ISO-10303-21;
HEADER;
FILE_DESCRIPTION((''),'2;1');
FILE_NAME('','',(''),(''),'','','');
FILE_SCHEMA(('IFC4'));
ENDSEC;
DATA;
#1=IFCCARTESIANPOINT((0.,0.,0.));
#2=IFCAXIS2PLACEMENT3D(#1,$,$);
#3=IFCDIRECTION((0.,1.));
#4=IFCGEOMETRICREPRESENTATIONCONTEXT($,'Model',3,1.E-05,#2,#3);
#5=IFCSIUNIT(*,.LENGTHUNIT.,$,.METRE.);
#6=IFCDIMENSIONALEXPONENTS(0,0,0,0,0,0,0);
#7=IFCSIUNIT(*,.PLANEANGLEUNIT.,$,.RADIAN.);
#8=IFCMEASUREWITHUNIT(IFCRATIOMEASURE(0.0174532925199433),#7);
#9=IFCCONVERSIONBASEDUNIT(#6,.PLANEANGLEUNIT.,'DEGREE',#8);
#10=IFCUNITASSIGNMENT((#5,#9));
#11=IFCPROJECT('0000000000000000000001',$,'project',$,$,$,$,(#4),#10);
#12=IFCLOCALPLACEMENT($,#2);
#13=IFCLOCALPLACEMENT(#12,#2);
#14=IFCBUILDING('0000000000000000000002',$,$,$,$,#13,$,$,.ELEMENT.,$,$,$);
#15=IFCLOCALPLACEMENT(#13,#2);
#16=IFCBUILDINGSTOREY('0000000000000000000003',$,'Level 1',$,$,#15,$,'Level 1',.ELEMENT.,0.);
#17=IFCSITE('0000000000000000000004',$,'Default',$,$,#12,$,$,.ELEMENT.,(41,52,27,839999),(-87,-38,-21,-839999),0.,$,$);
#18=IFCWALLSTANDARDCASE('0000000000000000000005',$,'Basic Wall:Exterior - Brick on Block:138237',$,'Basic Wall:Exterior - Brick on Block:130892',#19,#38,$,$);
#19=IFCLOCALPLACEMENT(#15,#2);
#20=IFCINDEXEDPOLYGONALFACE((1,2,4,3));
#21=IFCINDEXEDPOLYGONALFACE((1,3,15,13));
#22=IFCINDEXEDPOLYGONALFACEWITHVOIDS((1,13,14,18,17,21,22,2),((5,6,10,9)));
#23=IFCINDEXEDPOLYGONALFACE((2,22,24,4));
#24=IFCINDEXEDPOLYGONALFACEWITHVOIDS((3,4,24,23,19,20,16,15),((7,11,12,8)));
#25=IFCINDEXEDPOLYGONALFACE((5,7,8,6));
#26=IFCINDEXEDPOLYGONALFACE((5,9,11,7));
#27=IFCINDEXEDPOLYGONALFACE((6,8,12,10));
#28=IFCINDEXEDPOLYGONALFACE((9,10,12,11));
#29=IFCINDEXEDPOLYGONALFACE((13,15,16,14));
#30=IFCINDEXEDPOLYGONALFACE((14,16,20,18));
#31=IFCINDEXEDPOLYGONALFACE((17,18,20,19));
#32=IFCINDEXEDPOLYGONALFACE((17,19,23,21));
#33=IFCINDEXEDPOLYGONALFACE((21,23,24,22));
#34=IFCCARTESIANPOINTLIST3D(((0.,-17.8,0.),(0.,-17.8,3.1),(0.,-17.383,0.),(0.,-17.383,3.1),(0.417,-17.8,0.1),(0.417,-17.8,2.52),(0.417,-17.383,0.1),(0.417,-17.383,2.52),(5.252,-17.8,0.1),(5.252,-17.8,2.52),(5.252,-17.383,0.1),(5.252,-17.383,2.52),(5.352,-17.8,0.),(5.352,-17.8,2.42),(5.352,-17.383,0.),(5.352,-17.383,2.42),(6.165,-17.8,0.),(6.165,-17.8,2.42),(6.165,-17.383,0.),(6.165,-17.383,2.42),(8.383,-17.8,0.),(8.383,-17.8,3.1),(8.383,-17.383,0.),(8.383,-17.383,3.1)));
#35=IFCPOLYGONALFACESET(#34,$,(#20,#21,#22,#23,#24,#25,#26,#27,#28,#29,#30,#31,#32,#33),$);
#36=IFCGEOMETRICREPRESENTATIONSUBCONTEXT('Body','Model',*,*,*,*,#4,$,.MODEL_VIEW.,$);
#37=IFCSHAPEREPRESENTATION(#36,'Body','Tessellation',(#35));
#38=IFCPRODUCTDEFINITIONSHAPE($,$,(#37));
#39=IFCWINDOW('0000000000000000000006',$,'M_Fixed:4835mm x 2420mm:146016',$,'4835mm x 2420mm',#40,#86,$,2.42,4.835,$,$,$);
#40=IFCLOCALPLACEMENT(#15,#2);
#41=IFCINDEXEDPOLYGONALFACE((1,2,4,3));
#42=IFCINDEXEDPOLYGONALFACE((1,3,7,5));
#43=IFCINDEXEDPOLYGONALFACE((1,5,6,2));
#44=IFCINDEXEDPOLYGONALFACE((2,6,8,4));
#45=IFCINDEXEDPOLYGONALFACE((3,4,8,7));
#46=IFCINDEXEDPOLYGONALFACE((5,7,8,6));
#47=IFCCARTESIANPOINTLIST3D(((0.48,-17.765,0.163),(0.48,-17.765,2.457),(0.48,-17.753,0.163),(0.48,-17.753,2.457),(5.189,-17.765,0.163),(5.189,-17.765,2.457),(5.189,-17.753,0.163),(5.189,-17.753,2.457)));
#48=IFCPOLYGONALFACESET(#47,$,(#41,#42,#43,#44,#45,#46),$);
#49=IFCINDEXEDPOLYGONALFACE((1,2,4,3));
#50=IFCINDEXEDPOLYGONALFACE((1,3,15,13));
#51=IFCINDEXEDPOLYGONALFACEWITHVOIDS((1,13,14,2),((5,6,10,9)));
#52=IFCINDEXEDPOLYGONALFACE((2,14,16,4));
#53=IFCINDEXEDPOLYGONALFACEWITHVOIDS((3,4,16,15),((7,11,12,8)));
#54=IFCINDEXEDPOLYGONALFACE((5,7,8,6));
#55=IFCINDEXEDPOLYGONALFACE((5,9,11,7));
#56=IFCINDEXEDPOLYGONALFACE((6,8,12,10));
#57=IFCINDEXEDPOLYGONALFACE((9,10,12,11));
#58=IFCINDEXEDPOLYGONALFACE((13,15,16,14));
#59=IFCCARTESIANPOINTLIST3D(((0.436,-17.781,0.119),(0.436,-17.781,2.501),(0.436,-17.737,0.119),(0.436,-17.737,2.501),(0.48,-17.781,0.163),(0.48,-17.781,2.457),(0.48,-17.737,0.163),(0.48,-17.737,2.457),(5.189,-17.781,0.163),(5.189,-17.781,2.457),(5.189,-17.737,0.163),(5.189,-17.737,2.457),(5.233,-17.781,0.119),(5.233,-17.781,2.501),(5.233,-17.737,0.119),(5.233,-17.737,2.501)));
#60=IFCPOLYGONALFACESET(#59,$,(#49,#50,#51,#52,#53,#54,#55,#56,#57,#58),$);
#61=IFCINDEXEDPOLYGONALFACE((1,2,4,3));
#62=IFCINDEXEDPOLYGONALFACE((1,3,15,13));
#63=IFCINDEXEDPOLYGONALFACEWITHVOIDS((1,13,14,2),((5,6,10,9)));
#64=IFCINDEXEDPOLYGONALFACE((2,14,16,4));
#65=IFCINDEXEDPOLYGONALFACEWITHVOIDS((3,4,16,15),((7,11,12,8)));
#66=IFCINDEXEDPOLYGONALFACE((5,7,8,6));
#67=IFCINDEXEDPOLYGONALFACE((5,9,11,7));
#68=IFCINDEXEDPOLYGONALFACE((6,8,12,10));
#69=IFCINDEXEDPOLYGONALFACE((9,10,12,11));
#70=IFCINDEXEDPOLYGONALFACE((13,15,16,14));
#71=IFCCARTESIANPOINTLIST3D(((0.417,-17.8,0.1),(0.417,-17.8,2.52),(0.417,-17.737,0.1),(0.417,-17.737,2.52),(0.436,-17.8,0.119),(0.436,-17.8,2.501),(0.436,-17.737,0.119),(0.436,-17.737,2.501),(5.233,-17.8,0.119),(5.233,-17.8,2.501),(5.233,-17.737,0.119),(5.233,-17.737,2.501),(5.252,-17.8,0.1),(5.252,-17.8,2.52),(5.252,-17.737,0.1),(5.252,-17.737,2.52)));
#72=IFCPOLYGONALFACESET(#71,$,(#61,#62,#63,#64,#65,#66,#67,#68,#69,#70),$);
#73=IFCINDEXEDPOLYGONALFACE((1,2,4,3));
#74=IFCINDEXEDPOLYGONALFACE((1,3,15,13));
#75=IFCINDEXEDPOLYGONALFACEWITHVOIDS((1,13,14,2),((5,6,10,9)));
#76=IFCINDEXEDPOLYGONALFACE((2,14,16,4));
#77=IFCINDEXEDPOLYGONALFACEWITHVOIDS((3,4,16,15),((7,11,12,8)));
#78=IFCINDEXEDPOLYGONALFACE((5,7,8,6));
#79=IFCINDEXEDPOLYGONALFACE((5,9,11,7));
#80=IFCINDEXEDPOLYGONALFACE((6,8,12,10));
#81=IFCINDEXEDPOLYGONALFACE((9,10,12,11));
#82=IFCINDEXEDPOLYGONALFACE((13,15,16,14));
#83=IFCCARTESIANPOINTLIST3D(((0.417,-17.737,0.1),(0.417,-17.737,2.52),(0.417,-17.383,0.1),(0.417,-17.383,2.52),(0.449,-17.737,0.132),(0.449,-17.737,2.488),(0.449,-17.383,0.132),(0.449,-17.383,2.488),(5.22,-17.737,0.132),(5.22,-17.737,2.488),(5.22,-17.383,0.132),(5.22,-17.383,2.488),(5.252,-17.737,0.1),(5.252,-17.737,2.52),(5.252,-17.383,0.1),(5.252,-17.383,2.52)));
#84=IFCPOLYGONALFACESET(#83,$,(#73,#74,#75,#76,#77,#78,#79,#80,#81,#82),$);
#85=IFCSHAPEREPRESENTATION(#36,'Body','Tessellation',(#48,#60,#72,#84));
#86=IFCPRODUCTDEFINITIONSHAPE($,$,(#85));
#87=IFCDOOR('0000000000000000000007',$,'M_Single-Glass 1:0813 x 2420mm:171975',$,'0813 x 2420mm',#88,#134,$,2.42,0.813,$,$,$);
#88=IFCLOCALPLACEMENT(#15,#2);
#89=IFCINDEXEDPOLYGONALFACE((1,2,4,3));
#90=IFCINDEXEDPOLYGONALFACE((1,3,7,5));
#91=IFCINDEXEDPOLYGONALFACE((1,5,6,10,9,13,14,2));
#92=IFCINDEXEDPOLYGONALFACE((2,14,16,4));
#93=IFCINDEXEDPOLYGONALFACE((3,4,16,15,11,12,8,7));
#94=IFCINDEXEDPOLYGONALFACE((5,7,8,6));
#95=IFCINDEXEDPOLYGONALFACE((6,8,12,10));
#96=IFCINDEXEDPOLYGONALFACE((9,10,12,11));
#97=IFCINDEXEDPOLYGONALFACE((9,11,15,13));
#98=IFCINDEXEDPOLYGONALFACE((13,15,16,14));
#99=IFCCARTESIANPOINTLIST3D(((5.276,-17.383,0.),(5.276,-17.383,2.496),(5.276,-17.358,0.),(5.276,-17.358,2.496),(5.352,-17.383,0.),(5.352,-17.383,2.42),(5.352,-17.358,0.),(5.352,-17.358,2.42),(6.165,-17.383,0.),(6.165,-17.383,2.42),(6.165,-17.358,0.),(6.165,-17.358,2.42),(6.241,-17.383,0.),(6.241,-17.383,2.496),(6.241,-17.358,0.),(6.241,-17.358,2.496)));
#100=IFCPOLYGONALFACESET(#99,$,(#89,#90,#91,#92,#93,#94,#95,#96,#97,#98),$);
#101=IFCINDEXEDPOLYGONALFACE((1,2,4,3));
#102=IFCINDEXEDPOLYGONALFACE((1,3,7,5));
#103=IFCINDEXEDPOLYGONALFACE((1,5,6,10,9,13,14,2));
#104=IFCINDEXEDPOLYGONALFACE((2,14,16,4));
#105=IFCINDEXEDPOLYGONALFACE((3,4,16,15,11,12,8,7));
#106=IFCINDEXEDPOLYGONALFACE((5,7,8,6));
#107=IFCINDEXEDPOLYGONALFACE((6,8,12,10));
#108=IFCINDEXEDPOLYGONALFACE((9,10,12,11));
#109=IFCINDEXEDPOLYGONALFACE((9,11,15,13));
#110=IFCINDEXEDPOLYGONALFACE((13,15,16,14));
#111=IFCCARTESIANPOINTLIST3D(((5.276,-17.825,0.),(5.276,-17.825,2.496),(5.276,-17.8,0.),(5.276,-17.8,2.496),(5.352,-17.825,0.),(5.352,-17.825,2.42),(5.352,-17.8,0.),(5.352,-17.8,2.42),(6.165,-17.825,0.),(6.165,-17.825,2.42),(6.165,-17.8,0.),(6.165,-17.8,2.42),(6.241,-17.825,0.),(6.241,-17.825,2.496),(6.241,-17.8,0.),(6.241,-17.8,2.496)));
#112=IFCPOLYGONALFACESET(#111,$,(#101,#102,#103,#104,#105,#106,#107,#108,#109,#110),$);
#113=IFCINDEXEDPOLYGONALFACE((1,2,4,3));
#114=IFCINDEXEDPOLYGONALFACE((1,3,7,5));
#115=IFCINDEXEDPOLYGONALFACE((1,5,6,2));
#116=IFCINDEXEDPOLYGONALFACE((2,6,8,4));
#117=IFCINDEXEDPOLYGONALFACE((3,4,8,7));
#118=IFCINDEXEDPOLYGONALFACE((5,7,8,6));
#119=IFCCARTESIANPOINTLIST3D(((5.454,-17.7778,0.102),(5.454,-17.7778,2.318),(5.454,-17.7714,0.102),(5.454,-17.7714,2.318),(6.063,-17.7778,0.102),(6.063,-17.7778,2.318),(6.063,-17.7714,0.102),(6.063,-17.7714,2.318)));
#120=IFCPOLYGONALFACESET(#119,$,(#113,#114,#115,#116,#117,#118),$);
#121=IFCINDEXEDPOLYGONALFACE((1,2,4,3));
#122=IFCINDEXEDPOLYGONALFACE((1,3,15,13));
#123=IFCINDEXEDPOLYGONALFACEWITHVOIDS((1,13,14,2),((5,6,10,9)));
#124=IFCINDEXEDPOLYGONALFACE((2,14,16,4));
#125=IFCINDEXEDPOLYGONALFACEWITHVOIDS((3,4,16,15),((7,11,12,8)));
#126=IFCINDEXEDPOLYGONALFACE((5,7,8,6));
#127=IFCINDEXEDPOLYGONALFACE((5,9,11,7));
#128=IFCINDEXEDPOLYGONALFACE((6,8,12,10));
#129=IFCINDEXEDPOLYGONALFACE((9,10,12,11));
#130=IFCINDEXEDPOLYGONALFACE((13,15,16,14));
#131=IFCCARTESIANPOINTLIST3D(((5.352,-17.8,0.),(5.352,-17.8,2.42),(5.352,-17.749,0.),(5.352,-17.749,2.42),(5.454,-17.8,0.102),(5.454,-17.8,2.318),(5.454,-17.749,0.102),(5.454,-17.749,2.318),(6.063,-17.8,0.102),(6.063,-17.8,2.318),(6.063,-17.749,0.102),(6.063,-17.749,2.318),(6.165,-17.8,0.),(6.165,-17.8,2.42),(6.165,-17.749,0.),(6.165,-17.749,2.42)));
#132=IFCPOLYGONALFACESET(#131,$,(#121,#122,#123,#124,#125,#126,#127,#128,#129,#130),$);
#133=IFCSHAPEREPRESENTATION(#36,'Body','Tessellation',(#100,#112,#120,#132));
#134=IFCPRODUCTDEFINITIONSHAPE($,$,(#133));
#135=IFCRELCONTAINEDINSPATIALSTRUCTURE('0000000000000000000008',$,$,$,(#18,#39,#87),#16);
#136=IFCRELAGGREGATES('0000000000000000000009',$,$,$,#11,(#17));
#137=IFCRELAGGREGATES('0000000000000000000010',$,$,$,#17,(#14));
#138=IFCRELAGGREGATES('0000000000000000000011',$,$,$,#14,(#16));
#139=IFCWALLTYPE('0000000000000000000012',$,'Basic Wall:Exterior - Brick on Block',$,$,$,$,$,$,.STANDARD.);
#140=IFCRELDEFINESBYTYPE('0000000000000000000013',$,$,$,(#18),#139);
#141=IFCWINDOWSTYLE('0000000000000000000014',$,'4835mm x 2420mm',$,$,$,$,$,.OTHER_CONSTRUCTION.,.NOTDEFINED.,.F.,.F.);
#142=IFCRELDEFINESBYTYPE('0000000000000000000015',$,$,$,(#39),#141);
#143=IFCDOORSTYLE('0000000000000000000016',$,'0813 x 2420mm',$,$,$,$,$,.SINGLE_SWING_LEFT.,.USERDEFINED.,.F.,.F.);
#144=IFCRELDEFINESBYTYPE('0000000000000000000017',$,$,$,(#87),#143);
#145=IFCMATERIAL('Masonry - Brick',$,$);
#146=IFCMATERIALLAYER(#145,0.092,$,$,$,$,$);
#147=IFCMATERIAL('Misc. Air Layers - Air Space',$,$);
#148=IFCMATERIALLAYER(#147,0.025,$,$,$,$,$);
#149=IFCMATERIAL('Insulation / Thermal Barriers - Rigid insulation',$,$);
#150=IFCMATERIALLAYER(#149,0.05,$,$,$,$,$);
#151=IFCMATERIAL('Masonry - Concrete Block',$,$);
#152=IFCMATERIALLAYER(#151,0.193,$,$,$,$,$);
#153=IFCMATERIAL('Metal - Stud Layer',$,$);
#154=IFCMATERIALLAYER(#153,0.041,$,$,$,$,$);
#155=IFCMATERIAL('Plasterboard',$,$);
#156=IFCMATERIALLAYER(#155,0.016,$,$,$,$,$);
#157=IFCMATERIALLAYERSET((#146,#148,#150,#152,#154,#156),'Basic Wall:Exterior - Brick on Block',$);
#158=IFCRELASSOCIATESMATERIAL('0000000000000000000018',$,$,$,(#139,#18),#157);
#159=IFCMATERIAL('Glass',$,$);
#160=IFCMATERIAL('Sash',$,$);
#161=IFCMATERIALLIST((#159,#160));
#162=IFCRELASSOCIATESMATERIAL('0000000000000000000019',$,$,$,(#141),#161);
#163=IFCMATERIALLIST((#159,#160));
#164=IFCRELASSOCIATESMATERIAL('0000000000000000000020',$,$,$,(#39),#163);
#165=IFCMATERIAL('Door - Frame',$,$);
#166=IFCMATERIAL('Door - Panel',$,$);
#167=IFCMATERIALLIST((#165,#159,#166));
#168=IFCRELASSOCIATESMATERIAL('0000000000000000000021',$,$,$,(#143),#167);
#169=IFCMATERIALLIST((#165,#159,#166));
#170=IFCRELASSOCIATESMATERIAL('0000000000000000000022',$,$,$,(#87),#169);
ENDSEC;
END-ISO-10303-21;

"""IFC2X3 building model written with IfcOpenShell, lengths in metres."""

from ifc_helpers import new_model, entity, si_unit, converted_unit, direction, frame, frame_2d, origin, origin_2d_with_axis, place, context, subcontext, project, spatial, polyline, rectangle, outline, extrude, source, transform, mapped, material, material_list, layer, layer_set, layer_usage, type_object, type_shapes, element, fill, save


model = new_model("IFC2X3")

# Units and contexts
model_context = context("Model", 3, precision=1e-05, world=origin(), true_north=direction((0.0, 1.0)))
body_context = subcontext(model_context, "Body", "Model", "MODEL_VIEW")
ifc_project = project(units=[si_unit("LENGTHUNIT", "METRE"), converted_unit("PLANEANGLEUNIT", "DEGREE", entity("IfcRatioMeasure", 0.0174532925199433), si_unit("PLANEANGLEUNIT", "RADIAN"), dimensions=[0, 0, 0, 0, 0, 0, 0])], contexts=[model_context])

# Site, building, storey
site_placement = place(None, origin())
site = spatial("IfcSite", under=ifc_project, at=site_placement, Name="Default", CompositionType="ELEMENT", RefLatitude=(41, 52, 27, 839999), RefLongitude=(-87, -38, -21, -839999), RefElevation=0.0)
building_placement = place(site_placement, origin())
building = spatial("IfcBuilding", under=site, at=building_placement, CompositionType="ELEMENT")
storey_placement = place(building_placement, origin())
storey = spatial("IfcBuildingStorey", under=building, at=storey_placement, Name="Level 1", LongName="Level 1", CompositionType="ELEMENT", Elevation=0.0)

# Wall, openings, window, door
ifc_material_1 = material(Name="Masonry - Brick")
ifc_layer_1 = layer(ifc_material_1, 0.092)
ifc_material_2 = material(Name="Misc. Air Layers - Air Space")
ifc_layer_2 = layer(ifc_material_2, 0.025)
ifc_material_3 = material(Name="Insulation / Thermal Barriers - Rigid insulation")
ifc_layer_3 = layer(ifc_material_3, 0.05)
ifc_material_4 = material(Name="Masonry - Concrete Block")
ifc_layer_4 = layer(ifc_material_4, 0.193)
ifc_material_5 = material(Name="Metal - Stud Layer")
ifc_layer_5 = layer(ifc_material_5, 0.041)
ifc_material_6 = material(Name="Plasterboard")
ifc_layer_6 = layer(ifc_material_6, 0.016)
ifc_layer_set_1 = layer_set([ifc_layer_1, ifc_layer_2, ifc_layer_3, ifc_layer_4, ifc_layer_5, ifc_layer_6], Name="Basic Wall:Exterior - Brick on Block")
ifc_layer_usage_1 = layer_usage(ifc_layer_set_1, "AXIS2", "NEGATIVE", 0.2085)
wall_type_1 = type_object("IfcWallType", Name="Basic Wall:Exterior - Brick on Block", PredefinedType="STANDARD", material=ifc_layer_set_1)
wall_1_placement = place(storey_placement, frame((8.383, -17.5915, 0.0), z_axis=(0.0, 0.0, 1.0), x_axis=(-1.0, 0.0, 0.0)))
wall_1 = element("IfcWallStandardCase", 1, at=wall_1_placement, inside=storey, type_object=wall_type_1, material=ifc_layer_usage_1, Name="Basic Wall:Exterior - Brick on Block:138237", ObjectType="Basic Wall:Exterior - Brick on Block:130892", context=body_context, shape_type="SweptSolid", body=[
    extrude(rectangle(XDim=8.383, YDim=0.417, at=frame_2d((4.1915, 0.0), x_axis=(-1.0, 0.0))), origin(), (0.0, 0.0, 1.0), 3.1),
])
opening_1_placement = place(wall_1_placement, frame((2.218, -0.2085, 0.0)))
opening_1 = element("IfcOpeningElement", 2, at=opening_1_placement, cuts=wall_1, ObjectType="Opening", context=body_context, shape_type="SweptSolid", body=[
    extrude(rectangle(XDim=0.813, YDim=2.42, at=frame_2d((1.21, 0.4065), x_axis=(0.0, -1.0))), frame((0.0, 0.0, 0.0), z_axis=(0.0, 1.0, 0.0), x_axis=(0.0, 0.0, 1.0)), (0.0, 0.0, 1.0), 0.417),
])
opening_2_placement = place(wall_1_placement, frame((3.131, -0.2085, 0.1)))
opening_2 = element("IfcOpeningElement", 3, at=opening_2_placement, cuts=wall_1, ObjectType="Opening", context=body_context, shape_type="SweptSolid", body=[
    extrude(rectangle(XDim=2.42, YDim=4.835, at=frame_2d((1.21, 2.4175), x_axis=(1.0, 0.0))), frame((0.0, 0.0, 0.0), z_axis=(0.0, 1.0, 0.0), x_axis=(0.0, 0.0, 1.0)), (0.0, 0.0, 1.0), 0.417),
])
ifc_material_7 = material(Name="Glass")
ifc_material_8 = material(Name="Sash")
ifc_material_list_1 = material_list([ifc_material_7, ifc_material_8])
ifc_material_list_2 = material_list([ifc_material_7, ifc_material_8])
window_style_1 = type_object("IfcWindowStyle", Name="4835mm x 2420mm", ConstructionType="OTHER_CONSTRUCTION", OperationType="NOTDEFINED", ParameterTakesPrecedence=False, Sizeable=False, material=ifc_material_list_2)
shared_shape_1 = source(origin(), body_context, "Body", "SweptSolid", [
    extrude(rectangle(XDim=0.012, YDim=4.709, at=origin_2d_with_axis()), frame((2.4175, 0.376, 0.063), z_axis=(0.0, 0.0, 1.0), x_axis=(0.0, -1.0, 0.0)), (0.0, 0.0, 1.0), 2.294),
    extrude(outline(polyline([(-2.3985, -1.191), (2.3985, -1.191), (2.3985, 1.191), (-2.3985, 1.191), (-2.3985, -1.191)]), holes=[polyline([(-2.3545, -1.147), (-2.3545, 1.147), (2.3545, 1.147), (2.3545, -1.147), (-2.3545, -1.147)])]), frame((2.4175, 0.354, 1.21), z_axis=(0.0, 1.0, 0.0), x_axis=(1.0, 0.0, 0.0)), (0.0, 0.0, 1.0), 0.044),
    extrude(outline(polyline([(-2.4175, -1.21), (2.4175, -1.21), (2.4175, 1.21), (-2.4175, 1.21), (-2.4175, -1.21)]), holes=[polyline([(-2.3985, -1.191), (-2.3985, 1.191), (2.3985, 1.191), (2.3985, -1.191), (-2.3985, -1.191)])]), frame((2.4175, 0.354, 1.21), z_axis=(0.0, 1.0, 0.0), x_axis=(1.0, 0.0, 0.0)), (0.0, 0.0, 1.0), 0.063),
    extrude(outline(polyline([(-2.4175, -1.21), (2.4175, -1.21), (2.4175, 1.21), (-2.4175, 1.21), (-2.4175, -1.21)]), holes=[polyline([(-2.3855, -1.178), (-2.3855, 1.178), (2.3855, 1.178), (2.3855, -1.178), (-2.3855, -1.178)])]), frame((2.4175, 0.0, 1.21), z_axis=(0.0, 1.0, 0.0), x_axis=(1.0, 0.0, 0.0)), (0.0, 0.0, 1.0), 0.354),
])
type_shapes(window_style_1, [shared_shape_1])
window_1_placement = place(opening_2_placement, origin())
window_1 = element("IfcWindow", 4, at=window_1_placement, inside=storey, type_object=window_style_1, material=ifc_material_list_1, Name="M_Fixed:4835mm x 2420mm:146016", ObjectType="4835mm x 2420mm", OverallHeight=2.42, OverallWidth=4.835, context=body_context, shape_type="MappedRepresentation", body=[
    mapped(shared_shape_1, transform((0.0, 0.0, 0.0), scale=1.0)),
])
fill(opening_2, window_1)
ifc_material_9 = material(Name="Door - Frame")
ifc_material_10 = material(Name="Door - Panel")
ifc_material_list_3 = material_list([ifc_material_9, ifc_material_7, ifc_material_10])
ifc_material_list_4 = material_list([ifc_material_9, ifc_material_7, ifc_material_10])
door_style_1 = type_object("IfcDoorStyle", Name="0813 x 2420mm", ConstructionType="USERDEFINED", OperationType="SINGLE_SWING_LEFT", ParameterTakesPrecedence=False, Sizeable=False, material=ifc_material_list_4)
shared_shape_2 = source(origin(), body_context, "Body", "SweptSolid", [
    extrude(outline(polyline([(-0.4065, -1.191), (-0.4065, 1.229), (-0.4825, 1.229), (-0.4825, -1.267), (0.4825, -1.267), (0.4825, 1.229), (0.4065, 1.229), (0.4065, -1.191), (-0.4065, -1.191)])), frame((0.4065, 0.0, 1.229), z_axis=(0.0, 1.0, 0.0), x_axis=(1.0, 0.0, 0.0)), (0.0, 0.0, -1.0), 0.025),
    extrude(outline(polyline([(-0.4065, -1.191), (-0.4065, 1.229), (-0.4825, 1.229), (-0.4825, -1.267), (0.4825, -1.267), (0.4825, 1.229), (0.4065, 1.229), (0.4065, -1.191), (-0.4065, -1.191)])), frame((0.4065, 0.442, 1.229), z_axis=(0.0, 1.0, 0.0), x_axis=(1.0, 0.0, 0.0)), (0.0, 0.0, -1.0), 0.025),
    extrude(rectangle(XDim=0.609, YDim=0.0064, at=frame_2d((0.0, 0.0), x_axis=(1.0, 0.0))), frame((0.4065, 0.3916, 0.102)), (0.0, 0.0, 1.0), 2.216),
    extrude(outline(polyline([(-1.21, -0.4065), (1.21, -0.4065), (1.21, 0.4065), (-1.21, 0.4065), (-1.21, -0.4065)]), holes=[polyline([(-1.108, 0.3045), (1.108, 0.3045), (1.108, -0.3045), (-1.108, -0.3045), (-1.108, 0.3045)])]), frame((0.4065, 0.417, 1.21), z_axis=(0.0, -1.0, 0.0), x_axis=(0.0, 0.0, -1.0)), (0.0, 0.0, 1.0), 0.051),
])
type_shapes(door_style_1, [shared_shape_2])
door_1_placement = place(opening_1_placement, origin())
door_1 = element("IfcDoor", 5, at=door_1_placement, inside=storey, type_object=door_style_1, material=ifc_material_list_3, Name="M_Single-Glass 1:0813 x 2420mm:171975", ObjectType="0813 x 2420mm", OverallHeight=2.42, OverallWidth=0.813, context=body_context, shape_type="MappedRepresentation", body=[
    mapped(shared_shape_2, transform((0.0, 0.0, 0.0), scale=1.0)),
])
fill(opening_1, door_1)

save(model, "model.ifc")
